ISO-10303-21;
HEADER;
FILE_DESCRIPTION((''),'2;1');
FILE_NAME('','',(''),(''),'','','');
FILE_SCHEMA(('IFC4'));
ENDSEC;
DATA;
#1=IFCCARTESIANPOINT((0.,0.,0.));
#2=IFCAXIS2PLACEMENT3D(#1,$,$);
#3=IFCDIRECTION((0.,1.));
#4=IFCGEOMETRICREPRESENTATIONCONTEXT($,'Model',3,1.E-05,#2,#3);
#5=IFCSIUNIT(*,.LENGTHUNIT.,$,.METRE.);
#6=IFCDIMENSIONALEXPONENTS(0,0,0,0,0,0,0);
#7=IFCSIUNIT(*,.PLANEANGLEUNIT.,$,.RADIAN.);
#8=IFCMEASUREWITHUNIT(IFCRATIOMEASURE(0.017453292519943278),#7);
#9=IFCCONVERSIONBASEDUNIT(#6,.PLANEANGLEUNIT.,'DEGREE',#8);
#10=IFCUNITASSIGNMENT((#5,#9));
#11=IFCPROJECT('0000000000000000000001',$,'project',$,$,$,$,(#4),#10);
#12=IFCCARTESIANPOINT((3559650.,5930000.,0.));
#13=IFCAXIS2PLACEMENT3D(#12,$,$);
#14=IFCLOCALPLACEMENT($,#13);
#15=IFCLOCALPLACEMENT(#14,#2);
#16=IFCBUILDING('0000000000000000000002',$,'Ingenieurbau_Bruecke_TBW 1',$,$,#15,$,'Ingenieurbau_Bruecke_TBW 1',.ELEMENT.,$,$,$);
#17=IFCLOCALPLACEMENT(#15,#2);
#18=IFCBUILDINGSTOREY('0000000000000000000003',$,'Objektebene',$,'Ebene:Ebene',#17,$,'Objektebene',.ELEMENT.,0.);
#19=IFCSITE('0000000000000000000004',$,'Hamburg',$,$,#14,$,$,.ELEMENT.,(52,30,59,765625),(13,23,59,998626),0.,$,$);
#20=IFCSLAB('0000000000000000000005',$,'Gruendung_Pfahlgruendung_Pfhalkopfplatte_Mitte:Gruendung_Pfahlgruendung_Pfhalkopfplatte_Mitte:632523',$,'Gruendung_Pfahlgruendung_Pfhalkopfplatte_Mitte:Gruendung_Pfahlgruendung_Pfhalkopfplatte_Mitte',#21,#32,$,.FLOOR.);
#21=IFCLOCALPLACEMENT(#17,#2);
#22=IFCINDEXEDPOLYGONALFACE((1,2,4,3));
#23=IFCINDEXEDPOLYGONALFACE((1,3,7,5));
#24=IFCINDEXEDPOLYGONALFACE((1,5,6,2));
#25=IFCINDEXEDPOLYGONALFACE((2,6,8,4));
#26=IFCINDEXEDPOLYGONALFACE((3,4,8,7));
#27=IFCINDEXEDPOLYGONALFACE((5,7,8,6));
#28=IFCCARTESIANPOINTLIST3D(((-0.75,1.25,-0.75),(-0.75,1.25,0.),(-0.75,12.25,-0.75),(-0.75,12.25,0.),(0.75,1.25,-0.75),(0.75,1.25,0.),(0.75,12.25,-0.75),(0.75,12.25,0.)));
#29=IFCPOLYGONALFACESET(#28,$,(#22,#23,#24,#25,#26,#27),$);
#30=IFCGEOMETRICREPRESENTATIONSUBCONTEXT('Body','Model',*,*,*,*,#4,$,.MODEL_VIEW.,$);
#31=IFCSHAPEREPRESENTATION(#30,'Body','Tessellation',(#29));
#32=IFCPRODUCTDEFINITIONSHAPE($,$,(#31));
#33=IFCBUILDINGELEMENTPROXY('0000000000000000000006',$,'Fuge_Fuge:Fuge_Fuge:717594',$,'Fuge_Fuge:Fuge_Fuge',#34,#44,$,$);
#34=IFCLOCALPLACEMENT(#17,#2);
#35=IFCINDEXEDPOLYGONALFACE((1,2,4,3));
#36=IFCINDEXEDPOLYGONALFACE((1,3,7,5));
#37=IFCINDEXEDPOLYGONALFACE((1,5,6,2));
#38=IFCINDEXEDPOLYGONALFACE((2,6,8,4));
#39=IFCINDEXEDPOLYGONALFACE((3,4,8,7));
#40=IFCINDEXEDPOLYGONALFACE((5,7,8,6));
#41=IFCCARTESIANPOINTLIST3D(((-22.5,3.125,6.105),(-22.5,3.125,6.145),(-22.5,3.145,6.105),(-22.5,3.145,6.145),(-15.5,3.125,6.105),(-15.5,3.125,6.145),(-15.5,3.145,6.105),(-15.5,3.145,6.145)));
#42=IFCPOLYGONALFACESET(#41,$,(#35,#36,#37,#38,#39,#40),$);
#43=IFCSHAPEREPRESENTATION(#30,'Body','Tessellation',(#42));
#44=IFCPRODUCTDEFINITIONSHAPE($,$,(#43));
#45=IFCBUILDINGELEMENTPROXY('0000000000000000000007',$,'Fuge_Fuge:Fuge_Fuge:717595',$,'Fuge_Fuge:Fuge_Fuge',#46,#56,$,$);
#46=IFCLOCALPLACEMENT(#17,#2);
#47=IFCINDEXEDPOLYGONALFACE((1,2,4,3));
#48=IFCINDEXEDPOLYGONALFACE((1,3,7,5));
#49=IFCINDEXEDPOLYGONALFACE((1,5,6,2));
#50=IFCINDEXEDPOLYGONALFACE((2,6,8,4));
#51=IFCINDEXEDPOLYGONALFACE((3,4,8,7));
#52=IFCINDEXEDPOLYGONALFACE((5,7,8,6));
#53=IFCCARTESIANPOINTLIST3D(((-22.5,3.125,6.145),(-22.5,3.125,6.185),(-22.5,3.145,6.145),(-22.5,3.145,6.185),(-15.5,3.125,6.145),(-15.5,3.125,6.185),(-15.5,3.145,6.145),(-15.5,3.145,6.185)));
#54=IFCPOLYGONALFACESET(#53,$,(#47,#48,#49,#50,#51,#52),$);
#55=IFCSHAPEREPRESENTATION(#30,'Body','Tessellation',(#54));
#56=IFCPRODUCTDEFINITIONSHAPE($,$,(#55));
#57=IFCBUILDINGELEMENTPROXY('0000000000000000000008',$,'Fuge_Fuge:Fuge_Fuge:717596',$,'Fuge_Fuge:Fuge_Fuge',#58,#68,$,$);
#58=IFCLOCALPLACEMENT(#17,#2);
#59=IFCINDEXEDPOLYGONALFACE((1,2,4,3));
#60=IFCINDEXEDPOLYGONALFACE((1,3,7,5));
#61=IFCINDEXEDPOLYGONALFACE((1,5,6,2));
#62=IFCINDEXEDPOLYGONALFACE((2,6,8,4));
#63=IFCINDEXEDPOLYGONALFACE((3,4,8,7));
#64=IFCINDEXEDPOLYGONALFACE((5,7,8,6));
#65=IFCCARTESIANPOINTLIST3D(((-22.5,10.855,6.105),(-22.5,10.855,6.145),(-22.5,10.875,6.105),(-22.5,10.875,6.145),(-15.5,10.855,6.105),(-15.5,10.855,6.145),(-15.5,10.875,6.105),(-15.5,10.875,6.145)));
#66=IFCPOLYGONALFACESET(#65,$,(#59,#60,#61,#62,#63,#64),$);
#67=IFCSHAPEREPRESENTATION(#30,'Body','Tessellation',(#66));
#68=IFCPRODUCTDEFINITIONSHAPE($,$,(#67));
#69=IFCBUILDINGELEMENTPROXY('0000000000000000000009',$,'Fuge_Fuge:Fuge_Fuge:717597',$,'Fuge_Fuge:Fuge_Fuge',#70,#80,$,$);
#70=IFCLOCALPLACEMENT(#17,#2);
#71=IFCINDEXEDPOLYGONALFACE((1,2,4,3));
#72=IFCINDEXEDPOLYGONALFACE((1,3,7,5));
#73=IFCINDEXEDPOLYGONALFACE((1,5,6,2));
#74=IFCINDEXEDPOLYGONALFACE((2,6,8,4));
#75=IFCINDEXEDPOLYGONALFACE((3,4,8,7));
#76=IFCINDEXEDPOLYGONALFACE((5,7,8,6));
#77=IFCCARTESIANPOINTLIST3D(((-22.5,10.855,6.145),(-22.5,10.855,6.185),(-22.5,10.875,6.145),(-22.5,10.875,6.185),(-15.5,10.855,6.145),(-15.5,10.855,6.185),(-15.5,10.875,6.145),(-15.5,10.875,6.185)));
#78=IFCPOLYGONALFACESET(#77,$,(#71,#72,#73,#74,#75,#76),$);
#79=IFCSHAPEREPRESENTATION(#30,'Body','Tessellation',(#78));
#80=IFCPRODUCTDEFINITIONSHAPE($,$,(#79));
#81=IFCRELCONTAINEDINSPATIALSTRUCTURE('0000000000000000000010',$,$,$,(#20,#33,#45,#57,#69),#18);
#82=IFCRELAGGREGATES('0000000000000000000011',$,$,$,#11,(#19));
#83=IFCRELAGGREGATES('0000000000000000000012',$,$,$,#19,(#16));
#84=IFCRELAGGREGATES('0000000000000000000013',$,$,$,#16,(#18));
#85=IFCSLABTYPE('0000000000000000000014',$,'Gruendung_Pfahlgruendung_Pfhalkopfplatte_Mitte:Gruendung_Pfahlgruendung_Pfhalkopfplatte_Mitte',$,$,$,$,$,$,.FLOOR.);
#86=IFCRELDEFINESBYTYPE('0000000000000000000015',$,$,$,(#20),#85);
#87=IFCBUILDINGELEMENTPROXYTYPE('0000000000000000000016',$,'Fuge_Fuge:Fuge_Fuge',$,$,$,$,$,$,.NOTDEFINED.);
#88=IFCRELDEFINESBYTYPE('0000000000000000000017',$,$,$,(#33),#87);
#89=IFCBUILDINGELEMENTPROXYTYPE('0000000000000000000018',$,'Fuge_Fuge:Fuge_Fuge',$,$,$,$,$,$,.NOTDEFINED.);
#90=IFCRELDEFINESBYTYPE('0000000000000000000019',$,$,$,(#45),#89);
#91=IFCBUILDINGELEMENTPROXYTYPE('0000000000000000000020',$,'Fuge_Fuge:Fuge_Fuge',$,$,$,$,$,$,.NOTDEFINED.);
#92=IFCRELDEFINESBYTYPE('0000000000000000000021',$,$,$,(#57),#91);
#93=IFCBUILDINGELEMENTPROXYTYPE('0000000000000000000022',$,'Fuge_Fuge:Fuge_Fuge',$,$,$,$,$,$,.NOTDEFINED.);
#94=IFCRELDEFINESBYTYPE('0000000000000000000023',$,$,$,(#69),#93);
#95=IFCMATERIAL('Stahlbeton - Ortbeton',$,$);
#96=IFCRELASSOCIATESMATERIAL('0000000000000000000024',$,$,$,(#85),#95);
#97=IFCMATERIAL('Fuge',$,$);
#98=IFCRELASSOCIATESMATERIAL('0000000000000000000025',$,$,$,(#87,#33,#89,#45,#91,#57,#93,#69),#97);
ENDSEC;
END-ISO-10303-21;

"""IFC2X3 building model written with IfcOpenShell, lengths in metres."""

from ifc_helpers import new_model, entity, si_unit, converted_unit, direction, frame, frame_2d, origin, origin_2d_with_axis, place, context, subcontext, project, spatial, rectangle, extrude, source, transform, mapped, material, type_object, type_shapes, element, save


model = new_model("IFC2X3")

# Units and contexts
model_context = context("Model", 3, precision=1e-05, world=origin(), true_north=direction((0.0, 1.0)))
body_context = subcontext(model_context, "Body", "Model", "MODEL_VIEW")
ifc_project = project(units=[si_unit("LENGTHUNIT", "METRE"), converted_unit("PLANEANGLEUNIT", "DEGREE", entity("IfcRatioMeasure", 0.017453292519943278), si_unit("PLANEANGLEUNIT", "RADIAN"), dimensions=[0, 0, 0, 0, 0, 0, 0])], contexts=[model_context])

# Site, building, storey
site_placement = place(None, frame((3559650.0, 5930000.0, 0.0)))
site = spatial("IfcSite", under=ifc_project, at=site_placement, Name="Hamburg", CompositionType="ELEMENT", RefLatitude=(52, 30, 59, 765625), RefLongitude=(13, 23, 59, 998626), RefElevation=0.0)
building_placement = place(site_placement, origin())
building = spatial("IfcBuilding", under=site, at=building_placement, Name="Ingenieurbau_Bruecke_TBW 1", LongName="Ingenieurbau_Bruecke_TBW 1", CompositionType="ELEMENT")
storey_placement = place(building_placement, origin())
storey = spatial("IfcBuildingStorey", under=building, at=storey_placement, Name="Objektebene", ObjectType="Ebene:Ebene", LongName="Objektebene", CompositionType="ELEMENT", Elevation=0.0)

# Slab
ifc_material_1 = material(Name="Stahlbeton - Ortbeton")
slab_type_1 = type_object("IfcSlabType", Name="Gruendung_Pfahlgruendung_Pfhalkopfplatte_Mitte:Gruendung_Pfahlgruendung_Pfhalkopfplatte_Mitte", PredefinedType="FLOOR", material=ifc_material_1)
slab_1_placement = place(storey_placement, origin())
element("IfcSlab", 1, at=slab_1_placement, inside=storey, type_object=slab_type_1, Name="Gruendung_Pfahlgruendung_Pfhalkopfplatte_Mitte:Gruendung_Pfahlgruendung_Pfhalkopfplatte_Mitte:632523", ObjectType="Gruendung_Pfahlgruendung_Pfhalkopfplatte_Mitte:Gruendung_Pfahlgruendung_Pfhalkopfplatte_Mitte", PredefinedType="FLOOR", context=body_context, shape_type="SweptSolid", body=[
    extrude(rectangle(XDim=1.5, YDim=11.0, at=origin_2d_with_axis()), frame((0.0, 6.75, -0.75), z_axis=(0.0, 0.0, 1.0), x_axis=(-1.0, 0.0, 0.0)), (0.0, 0.0, 1.0), 0.75),
])

# Building element proxies
ifc_material_2 = material(Name="Fuge")
building_element_proxy_type_1 = type_object("IfcBuildingElementProxyType", Name="Fuge_Fuge:Fuge_Fuge", PredefinedType="NOTDEFINED", material=ifc_material_2)
shared_shape_1 = source(origin(), body_context, "Body", "SweptSolid", [
    extrude(rectangle(XDim=0.02, YDim=7.0, at=frame_2d((0.0, 0.0), x_axis=(1.0, 0.0))), frame((-19.0, 3.135, 6.105), z_axis=(0.0, 0.0, 1.0), x_axis=(0.0, -1.0, 0.0)), (0.0, 0.0, 1.0), 0.04),
])
type_shapes(building_element_proxy_type_1, [shared_shape_1])
proxy_1_placement = place(storey_placement, origin())
element("IfcBuildingElementProxy", 2, at=proxy_1_placement, inside=storey, type_object=building_element_proxy_type_1, material=ifc_material_2, Name="Fuge_Fuge:Fuge_Fuge:717594", ObjectType="Fuge_Fuge:Fuge_Fuge", context=body_context, shape_type="MappedRepresentation", body=[
    mapped(shared_shape_1, transform((0.0, 0.0, 0.0), scale=1.0)),
])
building_element_proxy_type_2 = type_object("IfcBuildingElementProxyType", Name="Fuge_Fuge:Fuge_Fuge", PredefinedType="NOTDEFINED", material=ifc_material_2)
shared_shape_2 = source(origin(), body_context, "Body", "SweptSolid", [
    extrude(rectangle(XDim=0.02, YDim=7.0, at=frame_2d((0.0, 0.0), x_axis=(1.0, 0.0))), frame((-19.0, 3.135, 6.145), z_axis=(0.0, 0.0, 1.0), x_axis=(0.0, -1.0, 0.0)), (0.0, 0.0, 1.0), 0.04),
])
type_shapes(building_element_proxy_type_2, [shared_shape_2])
proxy_2_placement = place(storey_placement, origin())
element("IfcBuildingElementProxy", 3, at=proxy_2_placement, inside=storey, type_object=building_element_proxy_type_2, material=ifc_material_2, Name="Fuge_Fuge:Fuge_Fuge:717595", ObjectType="Fuge_Fuge:Fuge_Fuge", context=body_context, shape_type="MappedRepresentation", body=[
    mapped(shared_shape_2, transform((0.0, 0.0, 0.0), scale=1.0)),
])
building_element_proxy_type_3 = type_object("IfcBuildingElementProxyType", Name="Fuge_Fuge:Fuge_Fuge", PredefinedType="NOTDEFINED", material=ifc_material_2)
shared_shape_3 = source(origin(), body_context, "Body", "SweptSolid", [
    extrude(rectangle(XDim=0.02, YDim=7.0, at=frame_2d((0.0, 0.0), x_axis=(1.0, 0.0))), frame((-19.0, 10.865, 6.105), z_axis=(0.0, 0.0, 1.0), x_axis=(0.0, -1.0, 0.0)), (0.0, 0.0, 1.0), 0.04),
])
type_shapes(building_element_proxy_type_3, [shared_shape_3])
proxy_3_placement = place(storey_placement, origin())
element("IfcBuildingElementProxy", 4, at=proxy_3_placement, inside=storey, type_object=building_element_proxy_type_3, material=ifc_material_2, Name="Fuge_Fuge:Fuge_Fuge:717596", ObjectType="Fuge_Fuge:Fuge_Fuge", context=body_context, shape_type="MappedRepresentation", body=[
    mapped(shared_shape_3, transform((0.0, 0.0, 0.0), scale=1.0)),
])
building_element_proxy_type_4 = type_object("IfcBuildingElementProxyType", Name="Fuge_Fuge:Fuge_Fuge", PredefinedType="NOTDEFINED", material=ifc_material_2)
shared_shape_4 = source(origin(), body_context, "Body", "SweptSolid", [
    extrude(rectangle(XDim=0.02, YDim=7.0, at=frame_2d((0.0, 0.0), x_axis=(1.0, 0.0))), frame((-19.0, 10.865, 6.145), z_axis=(0.0, 0.0, 1.0), x_axis=(0.0, -1.0, 0.0)), (0.0, 0.0, 1.0), 0.04),
])
type_shapes(building_element_proxy_type_4, [shared_shape_4])
proxy_4_placement = place(storey_placement, origin())
element("IfcBuildingElementProxy", 5, at=proxy_4_placement, inside=storey, type_object=building_element_proxy_type_4, material=ifc_material_2, Name="Fuge_Fuge:Fuge_Fuge:717597", ObjectType="Fuge_Fuge:Fuge_Fuge", context=body_context, shape_type="MappedRepresentation", body=[
    mapped(shared_shape_4, transform((0.0, 0.0, 0.0), scale=1.0)),
])

save(model, "model.ifc")
